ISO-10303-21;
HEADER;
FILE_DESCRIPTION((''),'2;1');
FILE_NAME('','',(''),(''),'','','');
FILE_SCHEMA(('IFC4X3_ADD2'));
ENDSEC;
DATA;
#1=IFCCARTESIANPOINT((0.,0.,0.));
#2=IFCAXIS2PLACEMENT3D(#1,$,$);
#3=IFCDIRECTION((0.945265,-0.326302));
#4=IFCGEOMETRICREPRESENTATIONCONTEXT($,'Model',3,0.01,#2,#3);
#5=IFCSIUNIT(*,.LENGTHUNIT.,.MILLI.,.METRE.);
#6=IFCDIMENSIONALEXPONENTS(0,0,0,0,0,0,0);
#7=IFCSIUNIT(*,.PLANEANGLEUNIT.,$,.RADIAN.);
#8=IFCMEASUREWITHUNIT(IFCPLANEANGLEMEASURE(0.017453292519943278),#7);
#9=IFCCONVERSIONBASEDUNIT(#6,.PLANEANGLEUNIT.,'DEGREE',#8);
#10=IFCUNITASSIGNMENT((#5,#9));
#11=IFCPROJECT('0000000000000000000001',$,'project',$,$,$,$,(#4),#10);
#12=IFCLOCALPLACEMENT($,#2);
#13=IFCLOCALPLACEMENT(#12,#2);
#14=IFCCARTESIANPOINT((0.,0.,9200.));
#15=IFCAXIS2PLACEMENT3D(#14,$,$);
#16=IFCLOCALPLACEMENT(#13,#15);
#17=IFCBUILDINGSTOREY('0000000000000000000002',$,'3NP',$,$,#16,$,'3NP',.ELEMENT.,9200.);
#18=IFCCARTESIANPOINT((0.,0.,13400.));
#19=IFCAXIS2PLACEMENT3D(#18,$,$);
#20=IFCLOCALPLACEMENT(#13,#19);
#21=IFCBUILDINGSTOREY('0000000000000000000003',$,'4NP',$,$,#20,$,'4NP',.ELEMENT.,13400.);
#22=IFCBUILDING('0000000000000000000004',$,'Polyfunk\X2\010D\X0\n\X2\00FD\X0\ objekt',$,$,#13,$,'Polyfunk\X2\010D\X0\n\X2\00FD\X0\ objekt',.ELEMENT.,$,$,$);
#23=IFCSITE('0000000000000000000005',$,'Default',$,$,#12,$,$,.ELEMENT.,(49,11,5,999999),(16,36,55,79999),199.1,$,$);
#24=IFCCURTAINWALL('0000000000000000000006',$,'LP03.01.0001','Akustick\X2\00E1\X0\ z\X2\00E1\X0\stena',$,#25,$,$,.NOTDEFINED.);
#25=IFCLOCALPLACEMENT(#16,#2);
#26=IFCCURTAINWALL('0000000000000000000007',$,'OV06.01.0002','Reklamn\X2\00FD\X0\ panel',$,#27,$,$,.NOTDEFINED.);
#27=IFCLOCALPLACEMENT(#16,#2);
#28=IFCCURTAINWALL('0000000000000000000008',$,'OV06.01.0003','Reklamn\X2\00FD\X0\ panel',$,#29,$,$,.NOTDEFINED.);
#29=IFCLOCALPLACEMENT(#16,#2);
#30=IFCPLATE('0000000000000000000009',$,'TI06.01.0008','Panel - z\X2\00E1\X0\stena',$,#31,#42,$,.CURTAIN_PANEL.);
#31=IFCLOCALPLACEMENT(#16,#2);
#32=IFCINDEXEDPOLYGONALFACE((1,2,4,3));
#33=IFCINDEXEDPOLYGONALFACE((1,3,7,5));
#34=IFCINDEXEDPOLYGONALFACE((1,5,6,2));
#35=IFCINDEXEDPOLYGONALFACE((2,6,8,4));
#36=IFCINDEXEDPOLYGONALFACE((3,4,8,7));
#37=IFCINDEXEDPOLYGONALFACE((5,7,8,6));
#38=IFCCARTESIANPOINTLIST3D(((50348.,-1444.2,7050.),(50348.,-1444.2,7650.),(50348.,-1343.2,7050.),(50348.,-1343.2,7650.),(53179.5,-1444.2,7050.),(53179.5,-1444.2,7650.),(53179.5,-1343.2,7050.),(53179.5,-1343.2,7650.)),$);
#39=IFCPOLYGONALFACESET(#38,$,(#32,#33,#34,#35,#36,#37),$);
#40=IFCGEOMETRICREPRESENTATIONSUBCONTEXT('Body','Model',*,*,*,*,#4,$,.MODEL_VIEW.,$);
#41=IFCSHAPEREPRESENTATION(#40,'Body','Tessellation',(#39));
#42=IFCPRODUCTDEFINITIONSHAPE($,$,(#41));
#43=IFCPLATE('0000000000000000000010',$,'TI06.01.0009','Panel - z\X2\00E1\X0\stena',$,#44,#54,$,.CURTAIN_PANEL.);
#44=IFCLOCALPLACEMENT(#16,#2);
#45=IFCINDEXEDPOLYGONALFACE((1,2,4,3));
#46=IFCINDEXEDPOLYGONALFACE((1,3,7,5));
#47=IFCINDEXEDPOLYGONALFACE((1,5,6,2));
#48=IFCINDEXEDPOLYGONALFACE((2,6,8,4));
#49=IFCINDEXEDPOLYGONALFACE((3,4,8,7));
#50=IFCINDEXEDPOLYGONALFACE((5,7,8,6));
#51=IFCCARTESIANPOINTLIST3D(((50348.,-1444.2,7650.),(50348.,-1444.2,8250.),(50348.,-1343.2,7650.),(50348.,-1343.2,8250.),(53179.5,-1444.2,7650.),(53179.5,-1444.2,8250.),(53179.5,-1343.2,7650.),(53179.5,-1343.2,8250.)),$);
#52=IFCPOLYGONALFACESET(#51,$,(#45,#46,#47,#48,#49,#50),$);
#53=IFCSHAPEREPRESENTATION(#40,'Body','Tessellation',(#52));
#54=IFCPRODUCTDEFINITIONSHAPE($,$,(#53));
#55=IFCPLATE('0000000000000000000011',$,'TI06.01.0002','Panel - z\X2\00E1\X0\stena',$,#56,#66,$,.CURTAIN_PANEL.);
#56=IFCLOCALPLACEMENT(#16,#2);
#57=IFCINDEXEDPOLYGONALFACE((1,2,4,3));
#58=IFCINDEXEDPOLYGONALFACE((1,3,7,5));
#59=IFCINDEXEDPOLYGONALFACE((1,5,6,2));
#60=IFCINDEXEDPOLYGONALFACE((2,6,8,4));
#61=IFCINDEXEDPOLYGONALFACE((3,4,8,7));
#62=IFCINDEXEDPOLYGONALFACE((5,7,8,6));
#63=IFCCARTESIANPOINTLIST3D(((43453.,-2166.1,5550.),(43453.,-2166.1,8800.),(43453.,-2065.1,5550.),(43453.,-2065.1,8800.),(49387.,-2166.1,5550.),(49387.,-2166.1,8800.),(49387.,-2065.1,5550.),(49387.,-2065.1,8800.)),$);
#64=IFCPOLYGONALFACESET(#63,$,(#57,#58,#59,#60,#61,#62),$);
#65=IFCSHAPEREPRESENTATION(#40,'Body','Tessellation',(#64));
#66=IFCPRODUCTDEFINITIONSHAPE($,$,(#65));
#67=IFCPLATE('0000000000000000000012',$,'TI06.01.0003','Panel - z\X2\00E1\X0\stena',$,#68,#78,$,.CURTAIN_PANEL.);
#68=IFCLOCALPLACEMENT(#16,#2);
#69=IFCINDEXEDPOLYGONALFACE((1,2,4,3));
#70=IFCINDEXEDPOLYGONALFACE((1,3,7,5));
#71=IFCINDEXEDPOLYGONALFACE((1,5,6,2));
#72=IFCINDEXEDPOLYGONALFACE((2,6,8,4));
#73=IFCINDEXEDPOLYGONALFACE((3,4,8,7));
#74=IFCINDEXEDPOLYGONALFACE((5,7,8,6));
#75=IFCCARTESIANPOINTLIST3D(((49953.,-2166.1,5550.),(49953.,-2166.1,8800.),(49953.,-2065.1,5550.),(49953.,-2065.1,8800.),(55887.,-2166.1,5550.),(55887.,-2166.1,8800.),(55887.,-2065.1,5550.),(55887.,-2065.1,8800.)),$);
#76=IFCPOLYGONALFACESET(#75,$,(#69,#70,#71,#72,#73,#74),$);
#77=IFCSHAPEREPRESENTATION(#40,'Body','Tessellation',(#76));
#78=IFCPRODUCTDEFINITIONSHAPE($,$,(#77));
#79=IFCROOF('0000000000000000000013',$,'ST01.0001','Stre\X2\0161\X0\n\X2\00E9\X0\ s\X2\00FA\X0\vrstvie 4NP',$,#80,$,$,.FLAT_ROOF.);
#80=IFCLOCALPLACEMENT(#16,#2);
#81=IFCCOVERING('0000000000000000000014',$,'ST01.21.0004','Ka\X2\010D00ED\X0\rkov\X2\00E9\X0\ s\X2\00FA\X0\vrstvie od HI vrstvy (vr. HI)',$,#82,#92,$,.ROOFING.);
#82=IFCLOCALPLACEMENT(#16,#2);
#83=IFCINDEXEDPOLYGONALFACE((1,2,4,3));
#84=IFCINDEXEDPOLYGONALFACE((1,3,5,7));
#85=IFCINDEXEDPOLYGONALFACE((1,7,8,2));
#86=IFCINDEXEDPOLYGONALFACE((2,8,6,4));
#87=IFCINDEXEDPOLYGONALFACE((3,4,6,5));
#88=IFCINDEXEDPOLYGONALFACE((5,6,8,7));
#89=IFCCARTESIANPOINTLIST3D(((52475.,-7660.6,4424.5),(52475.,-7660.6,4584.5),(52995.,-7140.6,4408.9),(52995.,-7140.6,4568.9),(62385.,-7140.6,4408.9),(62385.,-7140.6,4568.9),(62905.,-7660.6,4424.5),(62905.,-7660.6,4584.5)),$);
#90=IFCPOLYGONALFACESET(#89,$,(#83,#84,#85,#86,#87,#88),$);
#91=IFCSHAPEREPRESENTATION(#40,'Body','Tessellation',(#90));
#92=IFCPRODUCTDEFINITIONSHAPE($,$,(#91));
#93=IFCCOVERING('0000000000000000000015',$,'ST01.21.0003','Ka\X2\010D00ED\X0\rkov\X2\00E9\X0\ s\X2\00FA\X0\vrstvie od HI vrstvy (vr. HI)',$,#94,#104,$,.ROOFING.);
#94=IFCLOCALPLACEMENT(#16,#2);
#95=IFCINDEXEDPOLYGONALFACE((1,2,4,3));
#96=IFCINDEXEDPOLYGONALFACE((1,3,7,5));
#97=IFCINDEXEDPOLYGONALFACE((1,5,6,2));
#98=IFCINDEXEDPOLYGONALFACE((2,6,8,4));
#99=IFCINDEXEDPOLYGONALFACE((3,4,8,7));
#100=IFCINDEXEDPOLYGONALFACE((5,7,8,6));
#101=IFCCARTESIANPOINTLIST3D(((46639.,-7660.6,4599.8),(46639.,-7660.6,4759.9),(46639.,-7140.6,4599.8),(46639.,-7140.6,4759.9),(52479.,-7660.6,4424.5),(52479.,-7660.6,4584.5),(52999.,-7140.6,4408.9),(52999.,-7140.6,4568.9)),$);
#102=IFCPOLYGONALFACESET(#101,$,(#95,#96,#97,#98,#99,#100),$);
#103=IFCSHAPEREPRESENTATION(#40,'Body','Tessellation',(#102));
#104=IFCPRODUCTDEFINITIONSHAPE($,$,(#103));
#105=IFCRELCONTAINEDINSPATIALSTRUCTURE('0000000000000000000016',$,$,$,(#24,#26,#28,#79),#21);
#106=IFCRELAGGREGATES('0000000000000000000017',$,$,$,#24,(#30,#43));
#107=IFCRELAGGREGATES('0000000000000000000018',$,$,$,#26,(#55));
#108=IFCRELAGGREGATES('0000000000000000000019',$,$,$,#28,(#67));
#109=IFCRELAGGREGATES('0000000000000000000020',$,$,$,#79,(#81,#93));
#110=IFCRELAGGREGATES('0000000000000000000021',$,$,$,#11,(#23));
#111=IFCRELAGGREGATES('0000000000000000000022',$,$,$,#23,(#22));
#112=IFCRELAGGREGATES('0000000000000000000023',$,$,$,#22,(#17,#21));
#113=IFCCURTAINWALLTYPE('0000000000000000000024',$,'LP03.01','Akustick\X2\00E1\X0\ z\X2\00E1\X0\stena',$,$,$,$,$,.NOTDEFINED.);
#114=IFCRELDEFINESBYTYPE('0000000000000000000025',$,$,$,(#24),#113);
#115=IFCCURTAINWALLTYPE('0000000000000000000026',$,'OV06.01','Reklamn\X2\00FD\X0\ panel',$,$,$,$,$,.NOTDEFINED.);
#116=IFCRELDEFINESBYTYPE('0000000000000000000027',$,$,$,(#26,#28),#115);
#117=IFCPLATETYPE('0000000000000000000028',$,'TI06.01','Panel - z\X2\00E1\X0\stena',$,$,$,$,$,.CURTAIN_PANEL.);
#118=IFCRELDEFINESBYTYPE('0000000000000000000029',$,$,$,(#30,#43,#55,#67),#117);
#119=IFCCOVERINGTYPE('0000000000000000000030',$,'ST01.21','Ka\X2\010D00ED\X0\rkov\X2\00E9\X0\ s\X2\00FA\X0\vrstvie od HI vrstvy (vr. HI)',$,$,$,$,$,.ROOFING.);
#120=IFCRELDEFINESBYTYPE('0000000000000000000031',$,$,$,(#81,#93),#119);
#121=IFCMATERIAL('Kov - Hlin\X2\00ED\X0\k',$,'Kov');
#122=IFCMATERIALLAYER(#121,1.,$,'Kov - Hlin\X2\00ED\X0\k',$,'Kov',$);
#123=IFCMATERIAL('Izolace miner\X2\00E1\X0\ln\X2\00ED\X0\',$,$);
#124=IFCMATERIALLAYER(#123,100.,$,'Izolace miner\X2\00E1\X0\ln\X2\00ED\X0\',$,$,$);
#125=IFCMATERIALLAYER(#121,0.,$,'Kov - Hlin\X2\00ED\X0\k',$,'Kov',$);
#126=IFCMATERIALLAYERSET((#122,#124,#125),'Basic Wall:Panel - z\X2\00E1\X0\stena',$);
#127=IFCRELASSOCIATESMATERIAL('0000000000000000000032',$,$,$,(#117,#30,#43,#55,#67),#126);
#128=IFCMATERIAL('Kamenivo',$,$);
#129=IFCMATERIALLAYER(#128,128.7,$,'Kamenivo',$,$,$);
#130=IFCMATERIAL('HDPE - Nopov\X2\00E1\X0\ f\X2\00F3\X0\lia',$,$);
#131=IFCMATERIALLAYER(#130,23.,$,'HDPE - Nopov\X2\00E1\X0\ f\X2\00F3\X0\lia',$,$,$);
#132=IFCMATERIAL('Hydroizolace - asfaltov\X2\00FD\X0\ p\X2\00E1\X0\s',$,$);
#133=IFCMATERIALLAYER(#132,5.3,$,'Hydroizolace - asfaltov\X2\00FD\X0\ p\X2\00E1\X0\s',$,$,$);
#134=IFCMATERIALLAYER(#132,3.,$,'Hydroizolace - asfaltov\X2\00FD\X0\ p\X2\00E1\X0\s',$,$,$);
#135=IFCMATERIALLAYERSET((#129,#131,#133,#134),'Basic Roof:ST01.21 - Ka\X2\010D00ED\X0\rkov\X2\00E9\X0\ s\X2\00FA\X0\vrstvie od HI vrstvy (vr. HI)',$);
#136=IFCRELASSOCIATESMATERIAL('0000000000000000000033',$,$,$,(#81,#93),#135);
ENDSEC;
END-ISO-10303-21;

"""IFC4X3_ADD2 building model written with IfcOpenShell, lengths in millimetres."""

from ifc_helpers import new_model, entity, si_unit, converted_unit, direction, frame, frame_2d, origin, place, context, subcontext, project, spatial, polyline, rectangle, outline, extrude, material, layer, layer_set, layer_usage, type_object, element, aggregate, save


model = new_model("IFC4X3_ADD2")

# Units and contexts
model_context = context("Model", 3, precision=0.01, world=origin(), true_north=direction((0.945265, -0.326302)))
body_context = subcontext(model_context, "Body", "Model", "MODEL_VIEW")
ifc_project = project(units=[si_unit("LENGTHUNIT", "METRE", prefix="MILLI"), converted_unit("PLANEANGLEUNIT", "DEGREE", entity("IfcPlaneAngleMeasure", 0.017453292519943278), si_unit("PLANEANGLEUNIT", "RADIAN"), dimensions=[0, 0, 0, 0, 0, 0, 0])], contexts=[model_context])

# Site, building, storey
site_placement = place(None, origin())
site = spatial("IfcSite", under=ifc_project, at=site_placement, Name="Default", CompositionType="ELEMENT", RefLatitude=(49, 11, 5, 999999), RefLongitude=(16, 36, 55, 79999), RefElevation=199.1)
building_placement = place(site_placement, origin())
building = spatial("IfcBuilding", under=site, at=building_placement, Name="Polyfunkčný objekt", LongName="Polyfunkčný objekt", CompositionType="ELEMENT")
storey_1_placement = place(building_placement, frame((0.0, 0.0, 9200.0)))
storey_1 = spatial("IfcBuildingStorey", under=building, at=storey_1_placement, Name="3NP", LongName="3NP", CompositionType="ELEMENT", Elevation=9200.0)

# Shared definitions
storey_2_placement = place(building_placement, frame((0.0, 0.0, 13400.0)))
storey_2 = spatial("IfcBuildingStorey", under=building, at=storey_2_placement, Name="4NP", LongName="4NP", CompositionType="ELEMENT", Elevation=13400.0)

# Curtain wall
curtain_wall_type_1 = type_object("IfcCurtainWallType", Name="LP03.01", Description="Akustická zástena", PredefinedType="NOTDEFINED")
curtain_wall_1_placement = place(storey_2_placement, frame((0.0, 0.0, -13400.0)))
curtain_wall_1 = element("IfcCurtainWall", 1, at=curtain_wall_1_placement, inside=storey_2, type_object=curtain_wall_type_1, Name="LP03.01.0001", Description="Akustická zástena", PredefinedType="NOTDEFINED")

# Curtain walls
curtain_wall_type_2 = type_object("IfcCurtainWallType", Name="OV06.01", Description="Reklamný panel", PredefinedType="NOTDEFINED")
curtain_wall_2_placement = place(storey_2_placement, frame((0.0, 0.0, -13400.0)))
curtain_wall_2 = element("IfcCurtainWall", 2, at=curtain_wall_2_placement, inside=storey_2, type_object=curtain_wall_type_2, Name="OV06.01.0002", Description="Reklamný panel", PredefinedType="NOTDEFINED")
curtain_wall_3_placement = place(storey_2_placement, frame((0.0, 0.0, -13400.0)))
curtain_wall_3 = element("IfcCurtainWall", 3, at=curtain_wall_3_placement, inside=storey_2, type_object=curtain_wall_type_2, Name="OV06.01.0003", Description="Reklamný panel", PredefinedType="NOTDEFINED")

# Plates
ifc_material_1 = material(Name="Kov - Hliník", Category="Kov")
ifc_layer_1 = layer(ifc_material_1, 1.0, Name="Kov - Hliník", Category="Kov")
ifc_material_2 = material(Name="Izolace minerální")
ifc_layer_2 = layer(ifc_material_2, 100.0, Name="Izolace minerální")
ifc_layer_3 = layer(ifc_material_1, 0.0, Name="Kov - Hliník", Category="Kov")
ifc_layer_set_1 = layer_set([ifc_layer_1, ifc_layer_2, ifc_layer_3], Name="Basic Wall:Panel - zástena")
plate_type = type_object("IfcPlateType", Name="TI06.01", Description="Panel - zástena", PredefinedType="CURTAIN_PANEL", material=ifc_layer_set_1)
ifc_layer_usage_1 = layer_usage(ifc_layer_set_1, "AXIS2", "POSITIVE", -50.5)
plate_1_placement = place(storey_2_placement, frame((50348.0, -1393.7, 2850.0)))
plate_1 = element("IfcPlate", 4, at=plate_1_placement, type_object=plate_type, material=ifc_layer_usage_1, Name="TI06.01.0008", Description="Panel - zástena", PredefinedType="CURTAIN_PANEL", context=body_context, shape_type="SweptSolid", body=[
    extrude(rectangle(XDim=101.0, YDim=2831.5, at=frame_2d((0.0, 0.0), x_axis=(1.0, 0.0))), frame((1415.8, 0.0, 0.0), z_axis=(0.0, 0.0, 1.0), x_axis=(0.0, 1.0, 0.0)), (0.0, 0.0, 1.0), 600.0),
])
ifc_layer_usage_2 = layer_usage(ifc_layer_set_1, "AXIS2", "POSITIVE", -50.5)
plate_2_placement = place(storey_2_placement, frame((50348.0, -1393.7, 3450.0)))
plate_2 = element("IfcPlate", 5, at=plate_2_placement, type_object=plate_type, material=ifc_layer_usage_2, Name="TI06.01.0009", Description="Panel - zástena", PredefinedType="CURTAIN_PANEL", context=body_context, shape_type="SweptSolid", body=[
    extrude(rectangle(XDim=101.0, YDim=2831.5, at=frame_2d((0.0, 0.0), x_axis=(1.0, 0.0))), frame((1415.8, 0.0, 0.0), z_axis=(0.0, 0.0, 1.0), x_axis=(0.0, 1.0, 0.0)), (0.0, 0.0, 1.0), 600.0),
])
aggregate(curtain_wall_1, [plate_1, plate_2])
ifc_layer_usage_3 = layer_usage(ifc_layer_set_1, "AXIS2", "NEGATIVE", 50.5)
plate_3_placement = place(storey_2_placement, frame((43453.0, -2115.6, 1350.0)))
plate_3 = element("IfcPlate", 6, at=plate_3_placement, type_object=plate_type, material=ifc_layer_usage_3, Name="TI06.01.0002", Description="Panel - zástena", PredefinedType="CURTAIN_PANEL", context=body_context, shape_type="SweptSolid", body=[
    extrude(rectangle(XDim=101.0, YDim=5934.0, at=frame_2d((0.0, 0.0), x_axis=(1.0, 0.0))), frame((2967.0, 0.0, 0.0), z_axis=(0.0, 0.0, 1.0), x_axis=(0.0, 1.0, 0.0)), (0.0, 0.0, 1.0), 3250.0),
])
aggregate(curtain_wall_2, [plate_3])
ifc_layer_usage_4 = layer_usage(ifc_layer_set_1, "AXIS2", "NEGATIVE", 50.5)
plate_4_placement = place(storey_2_placement, frame((49953.0, -2115.6, 1350.0)))
plate_4 = element("IfcPlate", 7, at=plate_4_placement, type_object=plate_type, material=ifc_layer_usage_4, Name="TI06.01.0003", Description="Panel - zástena", PredefinedType="CURTAIN_PANEL", context=body_context, shape_type="SweptSolid", body=[
    extrude(rectangle(XDim=101.0, YDim=5934.0, at=frame_2d((0.0, 0.0), x_axis=(1.0, 0.0))), frame((2967.0, 0.0, 0.0), z_axis=(0.0, 0.0, 1.0), x_axis=(0.0, 1.0, 0.0)), (0.0, 0.0, 1.0), 3250.0),
])
aggregate(curtain_wall_3, [plate_4])

# Roof, coverings
roof = element("IfcRoof", 8, inside=storey_2, Name="ST01.0001", Description="Strešné súvrstvie 4NP", PredefinedType="FLAT_ROOF")
ifc_material_3 = material(Name="HDPE - Nopová fólia")
ifc_material_4 = material(Name="Hydroizolace - asfaltový pás")
ifc_material_5 = material(Name="Kamenivo")
ifc_layer_4 = layer(ifc_material_5, 128.7, Name="Kamenivo")
ifc_layer_5 = layer(ifc_material_3, 23.0, Name="HDPE - Nopová fólia")
ifc_layer_6 = layer(ifc_material_4, 5.3, Name="Hydroizolace - asfaltový pás")
ifc_layer_7 = layer(ifc_material_4, 3.0, Name="Hydroizolace - asfaltový pás")
ifc_layer_set_2 = layer_set([ifc_layer_4, ifc_layer_5, ifc_layer_6, ifc_layer_7], Name="Basic Roof:ST01.21 - Kačírkové súvrstvie od HI vrstvy (vr. HI)")
covering_type_1 = type_object("IfcCoveringType", Name="ST01.21", Description="Kačírkové súvrstvie od HI vrstvy (vr. HI)", PredefinedType="ROOFING")
placement_1 = place(storey_2_placement, frame((52475.0, -7660.6, 208.9)))
covering_1_placement = place(placement_1, origin())
covering_1 = element("IfcCovering", 9, at=covering_1_placement, type_object=covering_type_1, material=ifc_layer_set_2, Name="ST01.21.0004", Description="Kačírkové súvrstvie od HI vrstvy (vr. HI)", PredefinedType="ROOFING", context=body_context, shape_type="SweptSolid", body=[
    extrude(outline(polyline([(-4695.0, 260.1), (-5215.0, -260.1), (5215.0, -260.1), (4695.0, 260.1), (-4695.0, 260.1)])), frame((5215.0, 260.0, 7.8), z_axis=(0.0, 0.030015, 0.999549), x_axis=(1.0, 0.0, 0.0)), (0.0, -0.030015, 0.999549), 160.1),
])
placement_2 = place(storey_2_placement, frame((46639.0, -7660.6, 208.9)))
covering_2_placement = place(placement_2, origin())
covering_2 = element("IfcCovering", 10, at=covering_2_placement, type_object=covering_type_1, material=ifc_layer_set_2, Name="ST01.21.0003", Description="Kačírkové súvrstvie od HI vrstvy (vr. HI)", PredefinedType="ROOFING", context=body_context, shape_type="SweptSolid", body=[
    extrude(outline(polyline([(3181.4, 260.0), (-3181.4, 260.0), (-3181.4, -260.0), (2661.2, -260.0), (3181.4, 260.0)])), frame((3180.0, 260.0, 95.5), z_axis=(0.030015, 0.0, 0.999549), x_axis=(0.999549, 0.0, -0.030015)), (-0.030015, 0.0, 0.999549), 160.1),
])
aggregate(roof, [covering_1, covering_2])

save(model, "model.ifc")
